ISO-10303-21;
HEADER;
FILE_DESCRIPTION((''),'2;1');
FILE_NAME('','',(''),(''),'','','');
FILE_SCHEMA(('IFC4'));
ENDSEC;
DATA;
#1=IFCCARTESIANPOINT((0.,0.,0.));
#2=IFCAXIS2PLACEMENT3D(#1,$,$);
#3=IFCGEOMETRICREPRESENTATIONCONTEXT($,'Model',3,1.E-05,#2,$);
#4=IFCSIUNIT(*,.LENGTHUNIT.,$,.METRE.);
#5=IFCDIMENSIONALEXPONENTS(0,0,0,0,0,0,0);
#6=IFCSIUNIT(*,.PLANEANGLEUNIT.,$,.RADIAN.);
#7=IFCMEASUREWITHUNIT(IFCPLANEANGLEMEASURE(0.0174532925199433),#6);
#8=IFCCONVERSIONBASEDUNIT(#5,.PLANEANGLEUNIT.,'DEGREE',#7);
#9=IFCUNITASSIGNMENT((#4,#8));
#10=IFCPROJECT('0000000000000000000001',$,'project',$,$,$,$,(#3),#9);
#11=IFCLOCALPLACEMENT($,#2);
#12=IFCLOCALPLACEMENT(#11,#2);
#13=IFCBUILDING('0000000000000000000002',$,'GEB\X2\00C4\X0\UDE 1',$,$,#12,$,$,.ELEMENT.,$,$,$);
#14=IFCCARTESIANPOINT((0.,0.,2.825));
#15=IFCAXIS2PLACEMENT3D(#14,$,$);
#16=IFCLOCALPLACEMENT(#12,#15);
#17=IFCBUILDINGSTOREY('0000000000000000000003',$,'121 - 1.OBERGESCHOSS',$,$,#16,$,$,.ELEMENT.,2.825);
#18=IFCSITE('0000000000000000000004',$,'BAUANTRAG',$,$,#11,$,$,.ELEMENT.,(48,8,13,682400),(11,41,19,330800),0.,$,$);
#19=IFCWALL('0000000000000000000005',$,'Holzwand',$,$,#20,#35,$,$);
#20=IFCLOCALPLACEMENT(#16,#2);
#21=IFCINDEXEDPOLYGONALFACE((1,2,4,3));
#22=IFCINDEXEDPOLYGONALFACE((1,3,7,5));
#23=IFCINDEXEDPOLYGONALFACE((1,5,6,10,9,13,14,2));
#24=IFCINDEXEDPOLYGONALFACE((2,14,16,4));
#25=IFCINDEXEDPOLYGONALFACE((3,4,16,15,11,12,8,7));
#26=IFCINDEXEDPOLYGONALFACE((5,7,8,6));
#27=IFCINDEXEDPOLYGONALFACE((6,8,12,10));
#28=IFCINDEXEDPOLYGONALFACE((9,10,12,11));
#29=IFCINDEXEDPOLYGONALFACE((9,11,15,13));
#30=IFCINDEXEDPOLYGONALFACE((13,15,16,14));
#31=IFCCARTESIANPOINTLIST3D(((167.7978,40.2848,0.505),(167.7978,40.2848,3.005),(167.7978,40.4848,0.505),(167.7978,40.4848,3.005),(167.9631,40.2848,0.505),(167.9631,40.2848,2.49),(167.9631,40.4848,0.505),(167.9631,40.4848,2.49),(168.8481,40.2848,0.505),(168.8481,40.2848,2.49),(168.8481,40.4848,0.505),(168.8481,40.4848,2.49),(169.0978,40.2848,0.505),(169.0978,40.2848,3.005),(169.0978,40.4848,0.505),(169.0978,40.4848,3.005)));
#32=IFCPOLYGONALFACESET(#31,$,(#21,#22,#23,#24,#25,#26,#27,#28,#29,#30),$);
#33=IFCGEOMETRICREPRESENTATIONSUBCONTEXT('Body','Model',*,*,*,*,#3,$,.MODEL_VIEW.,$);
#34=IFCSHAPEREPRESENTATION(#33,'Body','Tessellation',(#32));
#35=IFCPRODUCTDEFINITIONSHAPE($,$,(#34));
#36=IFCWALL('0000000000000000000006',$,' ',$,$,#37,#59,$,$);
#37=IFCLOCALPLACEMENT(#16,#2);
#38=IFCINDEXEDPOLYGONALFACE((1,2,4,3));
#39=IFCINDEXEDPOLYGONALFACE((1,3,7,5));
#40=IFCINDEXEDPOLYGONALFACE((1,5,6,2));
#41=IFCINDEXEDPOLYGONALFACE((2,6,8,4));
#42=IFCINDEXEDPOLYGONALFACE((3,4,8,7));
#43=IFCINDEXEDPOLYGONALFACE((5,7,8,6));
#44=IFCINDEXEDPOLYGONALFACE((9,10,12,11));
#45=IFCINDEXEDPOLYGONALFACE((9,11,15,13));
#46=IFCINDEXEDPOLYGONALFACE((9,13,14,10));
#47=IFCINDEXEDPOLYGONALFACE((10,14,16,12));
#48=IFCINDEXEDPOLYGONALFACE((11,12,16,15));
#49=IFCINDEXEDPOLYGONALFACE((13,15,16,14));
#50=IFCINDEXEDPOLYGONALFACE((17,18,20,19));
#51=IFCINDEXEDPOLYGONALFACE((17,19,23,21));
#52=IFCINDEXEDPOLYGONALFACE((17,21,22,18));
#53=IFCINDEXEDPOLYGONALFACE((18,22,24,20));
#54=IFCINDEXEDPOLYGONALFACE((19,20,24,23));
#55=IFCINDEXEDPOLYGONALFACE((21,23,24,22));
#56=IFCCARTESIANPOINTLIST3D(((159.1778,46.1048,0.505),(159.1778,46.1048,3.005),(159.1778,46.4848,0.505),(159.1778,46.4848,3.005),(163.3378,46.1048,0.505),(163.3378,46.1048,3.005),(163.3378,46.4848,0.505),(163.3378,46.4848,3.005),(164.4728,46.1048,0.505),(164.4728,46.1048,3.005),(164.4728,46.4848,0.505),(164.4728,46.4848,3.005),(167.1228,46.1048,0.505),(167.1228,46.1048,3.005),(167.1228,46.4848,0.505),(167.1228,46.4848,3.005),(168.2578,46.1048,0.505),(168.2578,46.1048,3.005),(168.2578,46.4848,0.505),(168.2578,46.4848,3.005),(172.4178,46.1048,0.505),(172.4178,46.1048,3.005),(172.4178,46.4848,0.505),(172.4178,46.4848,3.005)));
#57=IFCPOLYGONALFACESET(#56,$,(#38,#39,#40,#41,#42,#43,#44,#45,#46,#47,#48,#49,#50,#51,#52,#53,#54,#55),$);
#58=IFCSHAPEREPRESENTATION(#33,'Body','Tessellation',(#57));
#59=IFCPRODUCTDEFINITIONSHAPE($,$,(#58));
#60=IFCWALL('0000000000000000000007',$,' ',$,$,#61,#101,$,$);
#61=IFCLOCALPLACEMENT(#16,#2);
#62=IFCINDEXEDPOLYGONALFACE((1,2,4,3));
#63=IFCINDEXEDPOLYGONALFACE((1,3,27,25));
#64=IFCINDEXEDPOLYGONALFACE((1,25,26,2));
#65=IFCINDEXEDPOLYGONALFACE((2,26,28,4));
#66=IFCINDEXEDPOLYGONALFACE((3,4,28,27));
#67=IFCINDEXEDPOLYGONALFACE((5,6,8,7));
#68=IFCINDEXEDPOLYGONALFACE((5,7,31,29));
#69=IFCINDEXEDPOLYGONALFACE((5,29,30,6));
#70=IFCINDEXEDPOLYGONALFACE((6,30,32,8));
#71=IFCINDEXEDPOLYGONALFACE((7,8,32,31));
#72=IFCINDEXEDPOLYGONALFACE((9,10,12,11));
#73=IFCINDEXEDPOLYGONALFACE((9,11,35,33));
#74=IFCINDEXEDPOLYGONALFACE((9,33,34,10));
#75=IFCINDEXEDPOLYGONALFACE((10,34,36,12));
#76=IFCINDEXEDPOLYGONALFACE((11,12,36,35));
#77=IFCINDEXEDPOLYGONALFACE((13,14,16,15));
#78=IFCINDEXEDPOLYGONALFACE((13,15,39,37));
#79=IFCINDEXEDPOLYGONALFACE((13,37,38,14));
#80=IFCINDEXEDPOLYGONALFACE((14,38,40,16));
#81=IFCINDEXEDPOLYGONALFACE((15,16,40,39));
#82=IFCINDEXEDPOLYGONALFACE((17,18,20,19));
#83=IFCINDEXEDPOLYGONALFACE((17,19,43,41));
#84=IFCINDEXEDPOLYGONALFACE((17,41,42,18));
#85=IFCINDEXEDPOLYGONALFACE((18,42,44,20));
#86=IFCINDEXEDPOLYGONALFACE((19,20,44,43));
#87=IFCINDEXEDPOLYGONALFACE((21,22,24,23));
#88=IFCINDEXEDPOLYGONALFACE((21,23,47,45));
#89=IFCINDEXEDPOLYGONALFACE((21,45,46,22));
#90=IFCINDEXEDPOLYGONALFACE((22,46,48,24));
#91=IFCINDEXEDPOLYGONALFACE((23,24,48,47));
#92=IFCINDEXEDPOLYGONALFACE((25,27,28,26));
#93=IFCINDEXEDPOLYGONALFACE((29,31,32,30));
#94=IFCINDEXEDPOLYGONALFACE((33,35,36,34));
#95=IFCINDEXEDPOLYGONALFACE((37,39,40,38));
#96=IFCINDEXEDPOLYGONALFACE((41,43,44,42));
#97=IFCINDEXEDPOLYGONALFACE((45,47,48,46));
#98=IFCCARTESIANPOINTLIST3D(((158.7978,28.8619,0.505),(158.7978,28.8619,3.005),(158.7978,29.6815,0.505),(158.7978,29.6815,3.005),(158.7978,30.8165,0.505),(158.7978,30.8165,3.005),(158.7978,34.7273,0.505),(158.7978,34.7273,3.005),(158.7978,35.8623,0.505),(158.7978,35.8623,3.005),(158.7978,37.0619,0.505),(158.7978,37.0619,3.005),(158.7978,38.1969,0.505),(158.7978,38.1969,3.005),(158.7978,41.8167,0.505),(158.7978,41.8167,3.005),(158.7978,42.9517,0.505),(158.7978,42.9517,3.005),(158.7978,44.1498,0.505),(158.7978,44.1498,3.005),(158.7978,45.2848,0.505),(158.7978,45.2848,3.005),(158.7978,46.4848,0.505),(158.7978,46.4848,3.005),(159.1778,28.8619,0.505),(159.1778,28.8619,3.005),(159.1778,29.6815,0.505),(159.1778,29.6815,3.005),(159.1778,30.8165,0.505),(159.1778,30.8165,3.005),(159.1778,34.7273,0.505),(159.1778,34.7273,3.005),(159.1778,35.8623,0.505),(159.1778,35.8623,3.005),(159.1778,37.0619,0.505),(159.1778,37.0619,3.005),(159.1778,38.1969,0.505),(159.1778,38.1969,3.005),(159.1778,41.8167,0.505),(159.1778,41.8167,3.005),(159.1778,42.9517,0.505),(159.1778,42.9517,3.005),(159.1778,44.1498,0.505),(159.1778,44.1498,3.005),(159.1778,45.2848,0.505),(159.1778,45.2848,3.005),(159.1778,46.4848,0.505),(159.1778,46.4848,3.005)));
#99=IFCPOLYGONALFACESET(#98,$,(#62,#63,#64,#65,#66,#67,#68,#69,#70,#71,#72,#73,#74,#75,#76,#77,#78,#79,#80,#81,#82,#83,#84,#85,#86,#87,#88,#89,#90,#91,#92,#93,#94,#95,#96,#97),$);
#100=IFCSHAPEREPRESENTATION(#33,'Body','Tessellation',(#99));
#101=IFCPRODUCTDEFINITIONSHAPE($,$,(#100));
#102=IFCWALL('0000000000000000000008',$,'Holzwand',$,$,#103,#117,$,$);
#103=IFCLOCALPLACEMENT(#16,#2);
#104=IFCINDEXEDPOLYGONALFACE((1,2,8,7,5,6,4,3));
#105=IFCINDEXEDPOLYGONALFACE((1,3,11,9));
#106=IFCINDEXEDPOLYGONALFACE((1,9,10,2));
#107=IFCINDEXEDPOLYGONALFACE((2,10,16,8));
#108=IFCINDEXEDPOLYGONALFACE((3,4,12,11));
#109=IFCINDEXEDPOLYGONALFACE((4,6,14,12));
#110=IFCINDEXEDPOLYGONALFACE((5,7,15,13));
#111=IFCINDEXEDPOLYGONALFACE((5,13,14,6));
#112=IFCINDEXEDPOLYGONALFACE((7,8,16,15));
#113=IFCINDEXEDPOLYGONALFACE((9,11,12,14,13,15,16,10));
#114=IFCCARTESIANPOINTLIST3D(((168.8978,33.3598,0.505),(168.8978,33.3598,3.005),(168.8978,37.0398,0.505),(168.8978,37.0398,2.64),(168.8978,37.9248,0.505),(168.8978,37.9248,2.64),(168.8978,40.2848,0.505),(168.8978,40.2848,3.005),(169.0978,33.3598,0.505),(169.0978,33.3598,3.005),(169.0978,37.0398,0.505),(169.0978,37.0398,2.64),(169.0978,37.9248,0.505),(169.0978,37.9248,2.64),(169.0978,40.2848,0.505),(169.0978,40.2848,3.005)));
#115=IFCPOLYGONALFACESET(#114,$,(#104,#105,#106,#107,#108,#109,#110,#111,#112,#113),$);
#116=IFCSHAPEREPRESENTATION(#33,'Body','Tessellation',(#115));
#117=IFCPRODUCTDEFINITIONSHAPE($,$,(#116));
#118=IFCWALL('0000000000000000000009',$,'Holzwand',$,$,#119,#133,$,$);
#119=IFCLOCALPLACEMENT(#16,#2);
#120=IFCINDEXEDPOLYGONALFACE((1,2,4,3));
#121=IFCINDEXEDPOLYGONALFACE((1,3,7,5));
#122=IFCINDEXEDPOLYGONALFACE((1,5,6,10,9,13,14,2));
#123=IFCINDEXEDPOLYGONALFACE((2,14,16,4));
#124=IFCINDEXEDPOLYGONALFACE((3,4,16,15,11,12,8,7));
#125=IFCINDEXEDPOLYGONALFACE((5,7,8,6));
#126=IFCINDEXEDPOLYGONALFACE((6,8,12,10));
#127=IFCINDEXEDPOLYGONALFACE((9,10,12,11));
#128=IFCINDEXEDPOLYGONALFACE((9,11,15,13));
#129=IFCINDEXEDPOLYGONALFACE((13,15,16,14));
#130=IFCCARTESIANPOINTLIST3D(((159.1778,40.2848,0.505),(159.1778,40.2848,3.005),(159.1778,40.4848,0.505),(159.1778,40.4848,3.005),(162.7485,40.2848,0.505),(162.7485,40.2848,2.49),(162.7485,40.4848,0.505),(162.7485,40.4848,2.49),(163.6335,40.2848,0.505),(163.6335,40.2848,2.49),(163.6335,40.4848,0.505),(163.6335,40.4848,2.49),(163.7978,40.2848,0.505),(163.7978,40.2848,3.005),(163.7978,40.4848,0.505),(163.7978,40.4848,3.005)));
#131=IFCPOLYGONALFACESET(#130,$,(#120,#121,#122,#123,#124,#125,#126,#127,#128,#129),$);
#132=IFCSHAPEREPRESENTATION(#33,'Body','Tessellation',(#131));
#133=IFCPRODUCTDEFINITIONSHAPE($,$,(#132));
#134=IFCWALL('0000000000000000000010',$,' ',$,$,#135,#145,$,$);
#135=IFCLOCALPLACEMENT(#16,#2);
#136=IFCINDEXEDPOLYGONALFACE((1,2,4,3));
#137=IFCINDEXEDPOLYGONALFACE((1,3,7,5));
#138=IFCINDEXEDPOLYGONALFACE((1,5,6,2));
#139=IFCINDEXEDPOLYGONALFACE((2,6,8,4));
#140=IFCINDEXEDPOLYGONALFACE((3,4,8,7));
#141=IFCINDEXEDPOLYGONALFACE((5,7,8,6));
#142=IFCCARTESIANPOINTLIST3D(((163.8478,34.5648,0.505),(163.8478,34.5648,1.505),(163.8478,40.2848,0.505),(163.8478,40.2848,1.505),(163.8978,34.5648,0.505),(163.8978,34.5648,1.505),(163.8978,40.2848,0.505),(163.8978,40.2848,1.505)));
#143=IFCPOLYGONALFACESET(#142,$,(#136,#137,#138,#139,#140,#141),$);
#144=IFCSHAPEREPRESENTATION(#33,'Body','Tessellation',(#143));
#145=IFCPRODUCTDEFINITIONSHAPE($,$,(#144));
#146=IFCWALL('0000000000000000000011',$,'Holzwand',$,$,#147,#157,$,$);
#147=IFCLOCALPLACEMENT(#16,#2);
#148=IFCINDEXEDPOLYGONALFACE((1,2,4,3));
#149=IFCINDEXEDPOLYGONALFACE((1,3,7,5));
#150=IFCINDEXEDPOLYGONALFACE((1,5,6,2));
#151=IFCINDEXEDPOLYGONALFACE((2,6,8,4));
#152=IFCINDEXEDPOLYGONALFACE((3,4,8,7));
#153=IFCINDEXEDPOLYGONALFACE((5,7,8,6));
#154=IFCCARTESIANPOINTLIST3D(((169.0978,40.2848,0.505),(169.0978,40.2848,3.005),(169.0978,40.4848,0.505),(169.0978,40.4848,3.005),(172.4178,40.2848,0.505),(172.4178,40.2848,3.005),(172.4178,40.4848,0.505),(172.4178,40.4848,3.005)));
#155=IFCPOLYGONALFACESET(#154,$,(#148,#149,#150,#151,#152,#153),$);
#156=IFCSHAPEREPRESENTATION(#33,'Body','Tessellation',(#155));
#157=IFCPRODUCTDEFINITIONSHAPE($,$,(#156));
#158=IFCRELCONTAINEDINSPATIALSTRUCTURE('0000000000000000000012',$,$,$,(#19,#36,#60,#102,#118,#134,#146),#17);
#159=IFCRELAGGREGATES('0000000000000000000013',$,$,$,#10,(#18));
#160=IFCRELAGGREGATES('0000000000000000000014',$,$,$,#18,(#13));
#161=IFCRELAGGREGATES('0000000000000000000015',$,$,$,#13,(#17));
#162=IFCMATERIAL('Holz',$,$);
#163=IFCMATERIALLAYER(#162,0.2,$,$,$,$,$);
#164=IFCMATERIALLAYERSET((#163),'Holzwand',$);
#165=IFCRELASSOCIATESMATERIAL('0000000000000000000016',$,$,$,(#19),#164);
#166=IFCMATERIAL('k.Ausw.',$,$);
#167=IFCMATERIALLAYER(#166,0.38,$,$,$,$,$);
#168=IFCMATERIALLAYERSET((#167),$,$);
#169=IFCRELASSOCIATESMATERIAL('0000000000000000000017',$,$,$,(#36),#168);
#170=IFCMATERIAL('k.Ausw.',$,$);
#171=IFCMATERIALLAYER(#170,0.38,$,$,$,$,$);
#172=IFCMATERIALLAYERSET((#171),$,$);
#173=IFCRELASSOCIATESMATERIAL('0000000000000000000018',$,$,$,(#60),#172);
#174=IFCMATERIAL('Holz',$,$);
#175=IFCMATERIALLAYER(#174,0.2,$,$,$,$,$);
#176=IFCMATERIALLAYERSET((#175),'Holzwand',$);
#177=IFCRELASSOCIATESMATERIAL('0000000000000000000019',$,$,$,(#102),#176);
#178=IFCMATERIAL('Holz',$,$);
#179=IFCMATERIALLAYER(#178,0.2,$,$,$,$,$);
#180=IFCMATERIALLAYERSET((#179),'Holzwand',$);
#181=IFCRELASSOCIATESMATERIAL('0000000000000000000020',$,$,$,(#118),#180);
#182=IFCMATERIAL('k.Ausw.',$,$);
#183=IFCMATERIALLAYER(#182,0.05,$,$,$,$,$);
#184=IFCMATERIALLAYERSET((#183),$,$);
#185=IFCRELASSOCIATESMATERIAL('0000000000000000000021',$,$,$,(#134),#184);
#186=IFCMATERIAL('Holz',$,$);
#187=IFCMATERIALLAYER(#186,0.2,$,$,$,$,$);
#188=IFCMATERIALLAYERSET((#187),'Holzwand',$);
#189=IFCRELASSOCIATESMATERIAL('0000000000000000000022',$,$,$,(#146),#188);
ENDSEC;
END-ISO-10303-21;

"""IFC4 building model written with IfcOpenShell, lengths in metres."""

from ifc_helpers import new_model, entity, si_unit, converted_unit, frame, frame_2d, origin, origin_with_axes, place, context, subcontext, project, spatial, polyline, rectangle, outline, extrude, material, layer, layer_set, layer_usage, element, save


model = new_model("IFC4")

# Units and contexts
model_context = context("Model", 3, precision=1e-05, world=origin())
body_context = subcontext(model_context, "Body", "Model", "MODEL_VIEW")
ifc_project = project(units=[si_unit("LENGTHUNIT", "METRE"), converted_unit("PLANEANGLEUNIT", "DEGREE", entity("IfcPlaneAngleMeasure", 0.0174532925199433), si_unit("PLANEANGLEUNIT", "RADIAN"), dimensions=[0, 0, 0, 0, 0, 0, 0])], contexts=[model_context])

# Site, building, storey
site_placement = place(None, origin())
site = spatial("IfcSite", under=ifc_project, at=site_placement, Name="BAUANTRAG", CompositionType="ELEMENT", RefLatitude=(48, 8, 13, 682400), RefLongitude=(11, 41, 19, 330800), RefElevation=0.0)
building_placement = place(site_placement, origin())
building = spatial("IfcBuilding", under=site, at=building_placement, Name="GEBÄUDE 1", CompositionType="ELEMENT")
storey_placement = place(building_placement, frame((0.0, 0.0, 2.825)))
storey = spatial("IfcBuildingStorey", under=building, at=storey_placement, Name="121 - 1.OBERGESCHOSS", CompositionType="ELEMENT", Elevation=2.825)

# Wall, opening
ifc_material_1 = material(Name="Holz")
ifc_layer_1 = layer(ifc_material_1, 0.2)
ifc_layer_set_1 = layer_set([ifc_layer_1], Name="Holzwand")
ifc_layer_usage_1 = layer_usage(ifc_layer_set_1, "AXIS2", "POSITIVE", 0.0)
wall_1_placement = place(storey_placement, frame((169.0978, 40.4848, 0.505), z_axis=(0.0, 0.0, 1.0), x_axis=(-1.0, 0.0, 0.0)))
wall_1 = element("IfcWall", 1, at=wall_1_placement, inside=storey, material=ifc_layer_usage_1, Name="Holzwand", context=body_context, shape_type="SweptSolid", body=[
    extrude(rectangle(XDim=1.3, YDim=0.2, at=frame_2d((0.65, 0.1), x_axis=(1.0, 0.0))), origin_with_axes(), (0.0, 0.0, 1.0), 2.5),
])
opening_1_placement = place(wall_1_placement, frame((1.1346, 0.2, -0.15), z_axis=(0.0, -1.0, 0.0), x_axis=(0.0, 0.0, 1.0)))
element("IfcOpeningElement", 2, at=opening_1_placement, cuts=wall_1, ObjectType="Opening", context=body_context, shape_type="SweptSolid", body=[
    extrude(outline(polyline([(0.0, 0.885), (2.135, 0.885), (2.135, 0.0), (0.0, 0.0), (0.0, 0.885)])), origin_with_axes(), (0.0, 0.0, 1.0), 0.2),
])

# Walls, openings
ifc_material_2 = material(Name="k.Ausw.")
ifc_layer_2 = layer(ifc_material_2, 0.38)
ifc_layer_set_2 = layer_set([ifc_layer_2])
ifc_layer_usage_2 = layer_usage(ifc_layer_set_2, "AXIS2", "POSITIVE", 0.0)
wall_2_placement = place(storey_placement, frame((172.4178, 46.4848, 0.505), z_axis=(0.0, 0.0, 1.0), x_axis=(-1.0, 0.0, 0.0)))
wall_2 = element("IfcWall", 3, at=wall_2_placement, inside=storey, material=ifc_layer_usage_2, Name=" ", context=body_context, shape_type="SweptSolid", body=[
    extrude(rectangle(XDim=13.24, YDim=0.38, at=frame_2d((6.62, 0.19), x_axis=(1.0, 0.0))), origin_with_axes(), (0.0, 0.0, 1.0), 2.5),
])
opening_2_placement = place(wall_2_placement, frame((9.08, 0.38, 0.0), z_axis=(0.0, -1.0, 0.0), x_axis=(0.0, 0.0, 1.0)))
element("IfcOpeningElement", 4, at=opening_2_placement, cuts=wall_2, ObjectType="Opening", context=body_context, shape_type="SweptSolid", body=[
    extrude(outline(polyline([(0.0, 1.135), (2.5, 1.135), (2.5, 0.0), (0.0, 0.0), (0.0, 1.135)])), origin_with_axes(), (0.0, 0.0, 1.0), 0.38),
])
opening_3_placement = place(wall_2_placement, frame((5.295, 0.38, 0.0), z_axis=(0.0, -1.0, 0.0), x_axis=(0.0, 0.0, 1.0)))
element("IfcOpeningElement", 5, at=opening_3_placement, cuts=wall_2, ObjectType="Opening", context=body_context, shape_type="SweptSolid", body=[
    extrude(outline(polyline([(0.0, 1.135), (2.5, 1.135), (2.5, 0.0), (0.0, 0.0), (0.0, 1.135)])), origin_with_axes(), (0.0, 0.0, 1.0), 0.38),
])
ifc_material_3 = material(Name="k.Ausw.")
ifc_layer_3 = layer(ifc_material_3, 0.38)
ifc_layer_set_3 = layer_set([ifc_layer_3])
ifc_layer_usage_3 = layer_usage(ifc_layer_set_3, "AXIS2", "POSITIVE", 0.0)
wall_3_placement = place(storey_placement, frame((158.7978, 46.4848, 0.505), z_axis=(0.0, 0.0, 1.0), x_axis=(0.0, -1.0, 0.0)))
wall_3 = element("IfcWall", 6, at=wall_3_placement, inside=storey, material=ifc_layer_usage_3, Name=" ", context=body_context, shape_type="SweptSolid", body=[
    extrude(rectangle(XDim=17.6229, YDim=0.38, at=frame_2d((8.8114, 0.19), x_axis=(1.0, 0.0))), origin_with_axes(), (0.0, 0.0, 1.0), 2.5),
])
opening_4_placement = place(wall_3_placement, frame((11.7575, 0.38, 0.0), z_axis=(0.0, -1.0, 0.0), x_axis=(0.0, 0.0, 1.0)))
element("IfcOpeningElement", 7, at=opening_4_placement, cuts=wall_3, ObjectType="Opening", context=body_context, shape_type="SweptSolid", body=[
    extrude(outline(polyline([(0.0, 1.135), (2.5, 1.135), (2.5, 0.0), (0.0, 0.0), (0.0, 1.135)])), origin_with_axes(), (0.0, 0.0, 1.0), 0.38),
])
opening_5_placement = place(wall_3_placement, frame((16.8033, 0.38, 0.0), z_axis=(0.0, -1.0, 0.0), x_axis=(0.0, 0.0, 1.0)))
element("IfcOpeningElement", 8, at=opening_5_placement, cuts=wall_3, ObjectType="Opening", context=body_context, shape_type="SweptSolid", body=[
    extrude(outline(polyline([(0.0, 1.135), (2.5, 1.135), (2.5, 0.0), (0.0, 0.0), (0.0, 1.135)])), origin_with_axes(), (0.0, 0.0, 1.0), 0.38),
])
opening_6_placement = place(wall_3_placement, frame((4.6681, 0.38, 0.0), z_axis=(0.0, -1.0, 0.0), x_axis=(0.0, 0.0, 1.0)))
element("IfcOpeningElement", 9, at=opening_6_placement, cuts=wall_3, ObjectType="Opening", context=body_context, shape_type="SweptSolid", body=[
    extrude(outline(polyline([(0.0, 1.135), (2.5, 1.135), (2.5, 0.0), (0.0, 0.0), (0.0, 1.135)])), origin_with_axes(), (0.0, 0.0, 1.0), 0.38),
])
opening_7_placement = place(wall_3_placement, frame((2.335, 0.38, 0.0), z_axis=(0.0, -1.0, 0.0), x_axis=(0.0, 0.0, 1.0)))
element("IfcOpeningElement", 10, at=opening_7_placement, cuts=wall_3, ObjectType="Opening", context=body_context, shape_type="SweptSolid", body=[
    extrude(outline(polyline([(0.0, 1.135), (2.5, 1.135), (2.5, 0.0), (0.0, 0.0), (0.0, 1.135)])), origin_with_axes(), (0.0, 0.0, 1.0), 0.38),
])
opening_8_placement = place(wall_3_placement, frame((9.4229, 0.38, 0.0), z_axis=(0.0, -1.0, 0.0), x_axis=(0.0, 0.0, 1.0)))
element("IfcOpeningElement", 11, at=opening_8_placement, cuts=wall_3, ObjectType="Opening", context=body_context, shape_type="SweptSolid", body=[
    extrude(outline(polyline([(0.0, 1.135), (2.5, 1.135), (2.5, 0.0), (0.0, 0.0), (0.0, 1.135)])), origin_with_axes(), (0.0, 0.0, 1.0), 0.38),
])

# Walls, openings
ifc_material_4 = material(Name="Holz")
ifc_layer_4 = layer(ifc_material_4, 0.2)
ifc_layer_set_4 = layer_set([ifc_layer_4], Name="Holzwand")
ifc_layer_usage_4 = layer_usage(ifc_layer_set_4, "AXIS2", "POSITIVE", 0.0)
wall_4_placement = place(storey_placement, frame((168.8978, 40.2848, 0.505), z_axis=(0.0, 0.0, 1.0), x_axis=(0.0, -1.0, 0.0)))
wall_4 = element("IfcWall", 12, at=wall_4_placement, inside=storey, material=ifc_layer_usage_4, Name="Holzwand", context=body_context, shape_type="SweptSolid", body=[
    extrude(rectangle(XDim=6.925, YDim=0.2, at=frame_2d((3.4625, 0.1), x_axis=(1.0, 0.0))), origin_with_axes(), (0.0, 0.0, 1.0), 2.5),
])
opening_9_placement = place(wall_4_placement, frame((3.245, 0.2, -0.15), z_axis=(0.0, -1.0, 0.0), x_axis=(0.0, 0.0, 1.0)))
element("IfcOpeningElement", 13, at=opening_9_placement, cuts=wall_4, ObjectType="Opening", context=body_context, shape_type="SweptSolid", body=[
    extrude(outline(polyline([(0.0, 0.885), (2.285, 0.885), (2.285, 0.0), (0.0, 0.0), (0.0, 0.885)])), origin_with_axes(), (0.0, 0.0, 1.0), 0.2),
])
ifc_material_5 = material(Name="Holz")
ifc_layer_5 = layer(ifc_material_5, 0.2)
ifc_layer_set_5 = layer_set([ifc_layer_5], Name="Holzwand")
ifc_layer_usage_5 = layer_usage(ifc_layer_set_5, "AXIS2", "POSITIVE", 0.0)
wall_5_placement = place(storey_placement, frame((163.7978, 40.4848, 0.505), z_axis=(0.0, 0.0, 1.0), x_axis=(-1.0, 0.0, 0.0)))
wall_5 = element("IfcWall", 14, at=wall_5_placement, inside=storey, material=ifc_layer_usage_5, Name="Holzwand", context=body_context, shape_type="SweptSolid", body=[
    extrude(rectangle(XDim=4.62, YDim=0.2, at=frame_2d((2.31, 0.1), x_axis=(1.0, 0.0))), origin_with_axes(), (0.0, 0.0, 1.0), 2.5),
])
opening_10_placement = place(wall_5_placement, frame((1.0492, 0.2, -0.15), z_axis=(0.0, -1.0, 0.0), x_axis=(0.0, 0.0, 1.0)))
element("IfcOpeningElement", 15, at=opening_10_placement, cuts=wall_5, ObjectType="Opening", context=body_context, shape_type="SweptSolid", body=[
    extrude(outline(polyline([(0.0, 0.885), (2.135, 0.885), (2.135, 0.0), (0.0, 0.0), (0.0, 0.885)])), origin_with_axes(), (0.0, 0.0, 1.0), 0.2),
])

# Walls
ifc_material_6 = material(Name="k.Ausw.")
ifc_layer_6 = layer(ifc_material_6, 0.05)
ifc_layer_set_6 = layer_set([ifc_layer_6])
ifc_layer_usage_6 = layer_usage(ifc_layer_set_6, "AXIS2", "POSITIVE", 0.0)
wall_6_placement = place(storey_placement, frame((163.8478, 40.2848, 0.505), z_axis=(0.0, 0.0, 1.0), x_axis=(0.0, -1.0, 0.0)))
element("IfcWall", 16, at=wall_6_placement, inside=storey, material=ifc_layer_usage_6, Name=" ", context=body_context, shape_type="SweptSolid", body=[
    extrude(rectangle(XDim=5.72, YDim=0.05, at=frame_2d((2.86, 0.025), x_axis=(1.0, 0.0))), origin_with_axes(), (0.0, 0.0, 1.0), 1.0),
])
ifc_material_7 = material(Name="Holz")
ifc_layer_7 = layer(ifc_material_7, 0.2)
ifc_layer_set_7 = layer_set([ifc_layer_7], Name="Holzwand")
ifc_layer_usage_7 = layer_usage(ifc_layer_set_7, "AXIS2", "POSITIVE", 0.0)
wall_7_placement = place(storey_placement, frame((172.4178, 40.4848, 0.505), z_axis=(0.0, 0.0, 1.0), x_axis=(-1.0, 0.0, 0.0)))
element("IfcWall", 17, at=wall_7_placement, inside=storey, material=ifc_layer_usage_7, Name="Holzwand", context=body_context, shape_type="SweptSolid", body=[
    extrude(rectangle(XDim=3.32, YDim=0.2, at=frame_2d((1.66, 0.1), x_axis=(1.0, 0.0))), origin_with_axes(), (0.0, 0.0, 1.0), 2.5),
])

save(model, "model.ifc")
